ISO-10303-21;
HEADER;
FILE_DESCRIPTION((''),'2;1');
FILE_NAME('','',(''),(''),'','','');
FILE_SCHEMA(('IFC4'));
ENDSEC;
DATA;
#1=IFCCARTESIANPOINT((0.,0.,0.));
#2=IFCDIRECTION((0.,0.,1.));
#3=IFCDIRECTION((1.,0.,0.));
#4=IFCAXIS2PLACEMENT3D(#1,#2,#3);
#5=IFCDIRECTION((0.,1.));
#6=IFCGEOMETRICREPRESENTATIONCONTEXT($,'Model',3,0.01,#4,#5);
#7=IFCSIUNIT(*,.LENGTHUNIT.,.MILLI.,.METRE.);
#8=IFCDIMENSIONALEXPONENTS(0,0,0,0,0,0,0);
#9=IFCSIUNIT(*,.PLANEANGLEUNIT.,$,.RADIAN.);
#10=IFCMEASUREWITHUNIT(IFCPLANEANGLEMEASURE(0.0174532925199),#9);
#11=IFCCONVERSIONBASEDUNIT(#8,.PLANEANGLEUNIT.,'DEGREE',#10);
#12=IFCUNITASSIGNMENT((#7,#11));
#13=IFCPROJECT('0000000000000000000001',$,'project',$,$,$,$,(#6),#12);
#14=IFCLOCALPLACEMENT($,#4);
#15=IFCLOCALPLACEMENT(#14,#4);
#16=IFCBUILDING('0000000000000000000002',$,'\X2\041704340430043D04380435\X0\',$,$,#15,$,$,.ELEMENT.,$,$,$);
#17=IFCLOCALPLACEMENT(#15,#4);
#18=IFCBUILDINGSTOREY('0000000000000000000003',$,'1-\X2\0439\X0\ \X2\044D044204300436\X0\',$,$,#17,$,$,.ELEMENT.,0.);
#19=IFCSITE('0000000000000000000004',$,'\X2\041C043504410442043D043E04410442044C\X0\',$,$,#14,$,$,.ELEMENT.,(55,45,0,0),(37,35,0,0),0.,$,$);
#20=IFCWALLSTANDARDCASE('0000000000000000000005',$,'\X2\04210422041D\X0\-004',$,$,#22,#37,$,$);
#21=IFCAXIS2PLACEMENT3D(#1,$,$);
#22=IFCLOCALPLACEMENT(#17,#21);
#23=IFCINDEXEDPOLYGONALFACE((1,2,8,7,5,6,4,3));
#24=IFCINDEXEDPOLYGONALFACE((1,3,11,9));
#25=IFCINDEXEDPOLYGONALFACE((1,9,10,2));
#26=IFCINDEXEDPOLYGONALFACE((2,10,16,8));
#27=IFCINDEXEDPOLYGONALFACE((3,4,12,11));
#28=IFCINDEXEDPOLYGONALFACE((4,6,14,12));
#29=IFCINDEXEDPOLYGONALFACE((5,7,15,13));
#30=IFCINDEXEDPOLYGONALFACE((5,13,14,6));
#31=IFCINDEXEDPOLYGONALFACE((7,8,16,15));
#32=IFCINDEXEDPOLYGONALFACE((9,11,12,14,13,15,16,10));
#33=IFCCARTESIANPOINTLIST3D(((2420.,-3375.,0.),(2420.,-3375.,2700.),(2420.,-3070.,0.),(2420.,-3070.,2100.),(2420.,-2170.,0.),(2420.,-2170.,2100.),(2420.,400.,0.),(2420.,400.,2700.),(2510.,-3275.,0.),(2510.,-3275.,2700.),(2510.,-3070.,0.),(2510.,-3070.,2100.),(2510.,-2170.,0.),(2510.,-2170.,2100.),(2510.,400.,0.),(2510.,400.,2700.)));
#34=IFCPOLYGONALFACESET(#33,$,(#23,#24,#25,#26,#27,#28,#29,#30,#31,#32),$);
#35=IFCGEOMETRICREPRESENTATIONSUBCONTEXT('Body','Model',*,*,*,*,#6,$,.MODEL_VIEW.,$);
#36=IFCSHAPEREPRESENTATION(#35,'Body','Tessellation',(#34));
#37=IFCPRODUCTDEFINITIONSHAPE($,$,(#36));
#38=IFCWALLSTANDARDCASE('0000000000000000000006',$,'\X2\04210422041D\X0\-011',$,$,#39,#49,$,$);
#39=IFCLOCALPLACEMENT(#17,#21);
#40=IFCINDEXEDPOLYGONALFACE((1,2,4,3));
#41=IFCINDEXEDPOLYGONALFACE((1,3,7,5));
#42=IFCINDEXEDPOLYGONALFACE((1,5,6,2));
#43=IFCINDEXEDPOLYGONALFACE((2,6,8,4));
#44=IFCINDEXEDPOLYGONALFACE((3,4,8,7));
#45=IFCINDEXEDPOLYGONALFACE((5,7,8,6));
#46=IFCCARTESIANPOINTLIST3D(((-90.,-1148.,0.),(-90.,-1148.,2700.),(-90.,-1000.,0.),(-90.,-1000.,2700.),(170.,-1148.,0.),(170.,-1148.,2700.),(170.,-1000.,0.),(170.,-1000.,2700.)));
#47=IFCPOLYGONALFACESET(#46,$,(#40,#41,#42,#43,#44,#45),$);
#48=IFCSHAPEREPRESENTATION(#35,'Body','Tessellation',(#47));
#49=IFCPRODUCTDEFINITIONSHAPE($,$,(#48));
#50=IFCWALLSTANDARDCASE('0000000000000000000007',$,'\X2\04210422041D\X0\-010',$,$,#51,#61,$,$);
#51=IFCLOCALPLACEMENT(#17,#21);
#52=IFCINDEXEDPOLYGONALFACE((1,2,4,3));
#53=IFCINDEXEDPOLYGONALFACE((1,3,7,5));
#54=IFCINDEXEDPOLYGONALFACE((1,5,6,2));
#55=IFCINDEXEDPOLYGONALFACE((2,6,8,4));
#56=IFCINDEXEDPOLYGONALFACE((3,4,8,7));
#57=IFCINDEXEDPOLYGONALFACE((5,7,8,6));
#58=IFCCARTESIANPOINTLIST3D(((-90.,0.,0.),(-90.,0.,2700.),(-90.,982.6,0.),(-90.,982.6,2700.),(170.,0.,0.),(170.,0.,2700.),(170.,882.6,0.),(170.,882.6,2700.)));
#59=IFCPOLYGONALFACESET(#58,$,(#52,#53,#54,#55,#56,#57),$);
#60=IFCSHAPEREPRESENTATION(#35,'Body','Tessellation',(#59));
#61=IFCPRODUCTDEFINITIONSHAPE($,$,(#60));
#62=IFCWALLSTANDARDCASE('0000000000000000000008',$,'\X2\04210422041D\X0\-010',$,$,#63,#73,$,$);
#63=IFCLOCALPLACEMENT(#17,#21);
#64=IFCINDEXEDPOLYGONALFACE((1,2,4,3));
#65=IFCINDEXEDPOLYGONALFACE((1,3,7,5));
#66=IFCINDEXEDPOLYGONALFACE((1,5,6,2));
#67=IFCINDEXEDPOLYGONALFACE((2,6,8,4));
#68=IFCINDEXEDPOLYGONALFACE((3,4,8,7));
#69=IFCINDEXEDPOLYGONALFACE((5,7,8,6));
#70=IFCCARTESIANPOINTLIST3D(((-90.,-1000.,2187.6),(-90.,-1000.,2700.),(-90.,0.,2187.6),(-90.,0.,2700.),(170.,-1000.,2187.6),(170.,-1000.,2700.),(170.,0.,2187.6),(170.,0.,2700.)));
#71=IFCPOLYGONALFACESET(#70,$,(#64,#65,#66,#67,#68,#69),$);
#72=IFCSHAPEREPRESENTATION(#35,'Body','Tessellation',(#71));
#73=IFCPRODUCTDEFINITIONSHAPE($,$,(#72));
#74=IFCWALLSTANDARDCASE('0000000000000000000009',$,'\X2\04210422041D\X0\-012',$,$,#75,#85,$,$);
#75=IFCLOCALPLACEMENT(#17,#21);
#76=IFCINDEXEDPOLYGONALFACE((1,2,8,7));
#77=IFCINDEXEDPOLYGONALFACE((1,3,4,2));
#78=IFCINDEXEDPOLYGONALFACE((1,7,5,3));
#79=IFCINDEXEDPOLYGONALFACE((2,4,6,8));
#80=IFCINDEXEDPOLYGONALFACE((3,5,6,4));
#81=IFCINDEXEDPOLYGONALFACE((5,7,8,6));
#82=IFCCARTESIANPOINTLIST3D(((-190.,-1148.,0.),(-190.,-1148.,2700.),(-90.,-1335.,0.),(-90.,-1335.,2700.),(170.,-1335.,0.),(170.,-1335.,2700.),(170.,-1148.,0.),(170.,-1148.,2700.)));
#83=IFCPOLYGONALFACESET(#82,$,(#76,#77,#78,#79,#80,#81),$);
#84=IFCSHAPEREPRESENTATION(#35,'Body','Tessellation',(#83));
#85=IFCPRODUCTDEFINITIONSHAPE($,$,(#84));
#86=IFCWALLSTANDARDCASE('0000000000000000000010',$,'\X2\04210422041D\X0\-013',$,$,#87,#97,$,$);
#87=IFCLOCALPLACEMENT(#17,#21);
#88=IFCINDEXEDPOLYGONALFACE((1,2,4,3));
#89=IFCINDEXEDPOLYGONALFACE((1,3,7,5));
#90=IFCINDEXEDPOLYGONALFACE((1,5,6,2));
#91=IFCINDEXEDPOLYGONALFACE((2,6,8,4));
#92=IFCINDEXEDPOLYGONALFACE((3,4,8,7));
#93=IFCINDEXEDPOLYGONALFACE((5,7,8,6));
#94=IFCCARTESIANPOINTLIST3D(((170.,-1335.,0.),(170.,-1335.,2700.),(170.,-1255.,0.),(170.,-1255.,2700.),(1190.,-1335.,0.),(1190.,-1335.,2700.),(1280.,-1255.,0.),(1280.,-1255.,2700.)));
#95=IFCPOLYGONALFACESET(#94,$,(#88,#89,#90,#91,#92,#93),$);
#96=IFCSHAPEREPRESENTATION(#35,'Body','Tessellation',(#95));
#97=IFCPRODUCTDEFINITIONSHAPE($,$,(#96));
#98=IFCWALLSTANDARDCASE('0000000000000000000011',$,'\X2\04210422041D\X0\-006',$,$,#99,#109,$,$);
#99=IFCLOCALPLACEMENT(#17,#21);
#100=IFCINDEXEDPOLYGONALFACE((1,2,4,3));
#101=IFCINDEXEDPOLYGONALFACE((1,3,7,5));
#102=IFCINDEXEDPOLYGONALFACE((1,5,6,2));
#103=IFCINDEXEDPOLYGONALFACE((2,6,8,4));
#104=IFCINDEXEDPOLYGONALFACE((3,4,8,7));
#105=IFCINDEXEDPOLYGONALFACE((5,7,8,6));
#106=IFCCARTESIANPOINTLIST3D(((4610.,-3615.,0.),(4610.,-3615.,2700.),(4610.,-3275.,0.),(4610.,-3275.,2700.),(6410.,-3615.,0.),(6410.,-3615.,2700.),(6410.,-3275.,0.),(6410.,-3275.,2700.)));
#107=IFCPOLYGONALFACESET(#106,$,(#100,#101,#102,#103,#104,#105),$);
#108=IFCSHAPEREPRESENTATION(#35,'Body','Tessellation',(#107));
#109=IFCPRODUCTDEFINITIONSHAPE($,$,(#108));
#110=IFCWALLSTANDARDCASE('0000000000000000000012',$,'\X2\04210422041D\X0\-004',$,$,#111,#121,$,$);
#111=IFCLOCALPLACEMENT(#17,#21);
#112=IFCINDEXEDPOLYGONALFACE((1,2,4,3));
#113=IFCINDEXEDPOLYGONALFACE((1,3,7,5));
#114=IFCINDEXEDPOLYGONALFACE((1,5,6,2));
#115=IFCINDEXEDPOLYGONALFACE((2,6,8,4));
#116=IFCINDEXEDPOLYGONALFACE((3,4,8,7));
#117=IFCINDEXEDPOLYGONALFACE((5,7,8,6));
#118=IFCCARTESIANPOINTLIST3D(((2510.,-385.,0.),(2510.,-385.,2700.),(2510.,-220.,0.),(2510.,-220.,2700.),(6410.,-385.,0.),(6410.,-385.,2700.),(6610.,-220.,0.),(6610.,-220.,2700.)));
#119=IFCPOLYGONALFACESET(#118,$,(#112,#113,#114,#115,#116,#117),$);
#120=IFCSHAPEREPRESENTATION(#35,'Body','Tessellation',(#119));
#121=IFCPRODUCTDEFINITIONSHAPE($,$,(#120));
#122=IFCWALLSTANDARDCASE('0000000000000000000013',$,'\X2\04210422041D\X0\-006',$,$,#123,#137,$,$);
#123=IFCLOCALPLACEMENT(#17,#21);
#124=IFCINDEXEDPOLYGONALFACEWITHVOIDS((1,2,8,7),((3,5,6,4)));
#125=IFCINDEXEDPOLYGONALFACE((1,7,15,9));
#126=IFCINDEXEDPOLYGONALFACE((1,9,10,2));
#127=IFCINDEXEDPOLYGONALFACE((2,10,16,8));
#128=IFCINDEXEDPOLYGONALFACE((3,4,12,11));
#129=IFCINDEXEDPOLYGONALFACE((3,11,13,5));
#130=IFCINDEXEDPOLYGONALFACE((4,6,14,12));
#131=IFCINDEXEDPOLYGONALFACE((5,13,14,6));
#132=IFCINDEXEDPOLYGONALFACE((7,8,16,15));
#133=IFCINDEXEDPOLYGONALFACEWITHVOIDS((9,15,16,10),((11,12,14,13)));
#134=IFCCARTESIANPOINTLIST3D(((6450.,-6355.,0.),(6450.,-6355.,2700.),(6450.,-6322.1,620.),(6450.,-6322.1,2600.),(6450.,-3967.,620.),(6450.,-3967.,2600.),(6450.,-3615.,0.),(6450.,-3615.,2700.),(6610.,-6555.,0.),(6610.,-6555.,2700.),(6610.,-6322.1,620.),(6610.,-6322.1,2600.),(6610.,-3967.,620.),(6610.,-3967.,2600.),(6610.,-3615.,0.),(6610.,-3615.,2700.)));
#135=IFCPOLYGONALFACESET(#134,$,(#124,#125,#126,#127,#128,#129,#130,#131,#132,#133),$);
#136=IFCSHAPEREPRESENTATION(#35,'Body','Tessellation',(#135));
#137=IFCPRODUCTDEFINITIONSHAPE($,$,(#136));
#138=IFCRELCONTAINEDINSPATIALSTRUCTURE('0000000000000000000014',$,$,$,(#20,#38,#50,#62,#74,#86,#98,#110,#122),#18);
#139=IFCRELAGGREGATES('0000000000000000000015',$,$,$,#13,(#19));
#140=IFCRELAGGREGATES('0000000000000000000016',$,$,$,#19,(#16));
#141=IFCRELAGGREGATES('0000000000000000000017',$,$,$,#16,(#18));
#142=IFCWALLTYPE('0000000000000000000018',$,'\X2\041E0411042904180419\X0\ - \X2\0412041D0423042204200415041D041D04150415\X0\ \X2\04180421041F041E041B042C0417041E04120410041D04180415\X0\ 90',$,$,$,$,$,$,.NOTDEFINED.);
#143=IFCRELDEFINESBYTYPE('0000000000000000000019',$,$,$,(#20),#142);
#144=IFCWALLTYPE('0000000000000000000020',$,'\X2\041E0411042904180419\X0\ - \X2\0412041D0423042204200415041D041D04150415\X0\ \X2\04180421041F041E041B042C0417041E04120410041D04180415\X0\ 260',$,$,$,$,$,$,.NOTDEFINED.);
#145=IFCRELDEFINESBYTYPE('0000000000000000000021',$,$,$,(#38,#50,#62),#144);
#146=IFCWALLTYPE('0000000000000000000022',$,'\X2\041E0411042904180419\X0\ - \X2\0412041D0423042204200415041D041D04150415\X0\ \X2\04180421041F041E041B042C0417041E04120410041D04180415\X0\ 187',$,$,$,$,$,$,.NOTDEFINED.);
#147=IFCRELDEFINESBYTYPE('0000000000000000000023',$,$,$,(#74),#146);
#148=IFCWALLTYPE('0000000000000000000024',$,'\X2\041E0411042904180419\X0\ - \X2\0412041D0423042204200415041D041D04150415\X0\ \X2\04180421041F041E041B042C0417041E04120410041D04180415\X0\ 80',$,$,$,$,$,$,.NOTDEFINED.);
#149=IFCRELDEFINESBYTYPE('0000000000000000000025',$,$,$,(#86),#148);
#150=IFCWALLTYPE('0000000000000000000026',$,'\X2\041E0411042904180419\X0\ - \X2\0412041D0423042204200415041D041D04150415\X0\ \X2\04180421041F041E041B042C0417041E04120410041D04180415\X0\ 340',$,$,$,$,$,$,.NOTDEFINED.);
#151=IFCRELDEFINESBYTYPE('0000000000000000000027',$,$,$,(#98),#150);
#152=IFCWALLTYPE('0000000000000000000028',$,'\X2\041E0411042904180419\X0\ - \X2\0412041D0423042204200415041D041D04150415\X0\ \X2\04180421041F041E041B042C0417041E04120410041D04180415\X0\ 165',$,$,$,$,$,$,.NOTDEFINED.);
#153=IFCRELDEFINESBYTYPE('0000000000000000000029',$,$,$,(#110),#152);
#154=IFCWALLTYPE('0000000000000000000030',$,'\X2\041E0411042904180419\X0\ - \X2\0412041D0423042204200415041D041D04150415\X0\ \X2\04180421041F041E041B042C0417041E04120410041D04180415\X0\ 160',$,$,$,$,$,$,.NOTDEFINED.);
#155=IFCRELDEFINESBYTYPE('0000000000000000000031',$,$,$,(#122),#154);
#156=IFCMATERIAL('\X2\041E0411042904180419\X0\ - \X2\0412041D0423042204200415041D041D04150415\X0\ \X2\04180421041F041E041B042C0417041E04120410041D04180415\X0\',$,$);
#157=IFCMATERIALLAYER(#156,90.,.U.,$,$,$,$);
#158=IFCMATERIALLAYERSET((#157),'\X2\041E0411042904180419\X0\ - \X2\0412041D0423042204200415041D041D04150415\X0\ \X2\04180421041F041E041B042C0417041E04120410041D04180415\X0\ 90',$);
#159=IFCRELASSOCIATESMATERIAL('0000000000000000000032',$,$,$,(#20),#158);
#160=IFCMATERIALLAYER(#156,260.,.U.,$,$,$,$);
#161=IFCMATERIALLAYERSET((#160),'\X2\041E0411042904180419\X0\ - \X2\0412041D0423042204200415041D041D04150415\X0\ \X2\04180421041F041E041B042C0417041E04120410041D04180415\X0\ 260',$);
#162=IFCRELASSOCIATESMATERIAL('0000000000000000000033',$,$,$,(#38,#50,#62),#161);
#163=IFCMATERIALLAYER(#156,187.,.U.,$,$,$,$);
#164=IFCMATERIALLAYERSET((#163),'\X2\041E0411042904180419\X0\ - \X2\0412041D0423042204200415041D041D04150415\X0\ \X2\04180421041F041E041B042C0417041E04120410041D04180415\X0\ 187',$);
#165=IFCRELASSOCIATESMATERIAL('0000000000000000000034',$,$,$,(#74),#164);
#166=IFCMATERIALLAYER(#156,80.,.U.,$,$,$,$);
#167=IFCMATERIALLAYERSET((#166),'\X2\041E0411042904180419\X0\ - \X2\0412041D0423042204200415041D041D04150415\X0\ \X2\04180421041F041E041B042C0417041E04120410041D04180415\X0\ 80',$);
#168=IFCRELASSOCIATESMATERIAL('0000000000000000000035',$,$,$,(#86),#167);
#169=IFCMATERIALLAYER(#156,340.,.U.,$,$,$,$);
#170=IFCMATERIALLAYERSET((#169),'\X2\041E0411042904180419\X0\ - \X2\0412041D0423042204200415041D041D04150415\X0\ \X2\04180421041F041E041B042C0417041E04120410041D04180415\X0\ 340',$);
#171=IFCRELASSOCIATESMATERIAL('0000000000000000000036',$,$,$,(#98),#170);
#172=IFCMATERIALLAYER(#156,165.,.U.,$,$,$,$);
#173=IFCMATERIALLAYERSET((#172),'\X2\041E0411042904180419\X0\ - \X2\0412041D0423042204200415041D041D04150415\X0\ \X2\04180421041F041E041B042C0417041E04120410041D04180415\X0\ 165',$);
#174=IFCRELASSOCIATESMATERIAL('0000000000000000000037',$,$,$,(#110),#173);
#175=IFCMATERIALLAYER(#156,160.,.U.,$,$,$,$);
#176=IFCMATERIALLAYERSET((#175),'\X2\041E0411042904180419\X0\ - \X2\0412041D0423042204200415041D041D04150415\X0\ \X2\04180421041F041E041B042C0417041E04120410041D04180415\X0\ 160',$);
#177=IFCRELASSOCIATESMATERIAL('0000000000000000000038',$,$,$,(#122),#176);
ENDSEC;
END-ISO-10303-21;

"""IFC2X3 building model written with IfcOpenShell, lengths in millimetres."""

from ifc_helpers import new_model, entity, si_unit, converted_unit, direction, frame, origin_with_axes, origin_2d_with_axis, place, context, subcontext, project, spatial, polyline, rectangle, outline, extrude, material, layer, layer_set, layer_usage, type_object, element, save


model = new_model("IFC2X3")

# Units and contexts
model_context = context("Model", 3, precision=0.01, world=origin_with_axes(), true_north=direction((0.0, 1.0)))
body_context = subcontext(model_context, "Body", "Model", "MODEL_VIEW")
ifc_project = project(units=[si_unit("LENGTHUNIT", "METRE", prefix="MILLI"), converted_unit("PLANEANGLEUNIT", "DEGREE", entity("IfcPlaneAngleMeasure", 0.0174532925199), si_unit("PLANEANGLEUNIT", "RADIAN"), dimensions=[0, 0, 0, 0, 0, 0, 0])], contexts=[model_context])

# Site, building, storey
site_placement = place(None, origin_with_axes())
site = spatial("IfcSite", under=ifc_project, at=site_placement, Name="Местность", CompositionType="ELEMENT", RefLatitude=(55, 45, 0, 0), RefLongitude=(37, 35, 0, 0), RefElevation=0.0)
building_placement = place(site_placement, origin_with_axes())
building = spatial("IfcBuilding", under=site, at=building_placement, Name="Здание", CompositionType="ELEMENT")
storey_placement = place(building_placement, origin_with_axes())
storey = spatial("IfcBuildingStorey", under=building, at=storey_placement, Name="1-й этаж", CompositionType="ELEMENT", Elevation=0.0)

# Shared definitions
ifc_material = material(Name="ОБЩИЙ - ВНУТРЕННЕЕ ИСПОЛЬЗОВАНИЕ")

# Shared definitions
ifc_layer_1 = layer(ifc_material, 90.0, ventilated="UNKNOWN")
ifc_layer_set_1 = layer_set([ifc_layer_1], Name="ОБЩИЙ - ВНУТРЕННЕЕ ИСПОЛЬЗОВАНИЕ 90")
wall_type_1 = type_object("IfcWallType", Name="ОБЩИЙ - ВНУТРЕННЕЕ ИСПОЛЬЗОВАНИЕ 90", PredefinedType="NOTDEFINED")

# Wall, opening
ifc_layer_usage_1 = layer_usage(ifc_layer_set_1, "AXIS2", "POSITIVE", -90.0)
wall_1_placement = place(storey_placement, frame((2510.0, 400.0, 0.0), z_axis=(0.0, 0.0, 1.0), x_axis=(0.0, -1.0, 0.0)))
wall_1 = element("IfcWallStandardCase", 1, at=wall_1_placement, inside=storey, type_object=wall_type_1, material=ifc_layer_usage_1, Name="СТН-004", context=body_context, shape_type="SweptSolid", body=[
    extrude(outline(polyline([(0.0, -90.0), (3775.0, -90.0), (3675.0, 0.0), (0.0, 0.0), (0.0, -90.0)])), origin_with_axes(), (0.0, 0.0, 1.0), 2700.0),
])
opening_1_placement = place(wall_1_placement, frame((3020.0, 0.0, 0.0), z_axis=(0.0, 0.0, 1.0), x_axis=(1.0, 0.0, 0.0)))
element("IfcOpeningElement", 2, at=opening_1_placement, cuts=wall_1, context=body_context, shape_type="SweptSolid", body=[
    extrude(rectangle(XDim=900.0, YDim=2100.0, at=origin_2d_with_axis()), frame((0.0, 90.0, 1050.0), z_axis=(0.0, -1.0, 0.0), x_axis=(1.0, 0.0, 0.0)), (0.0, 0.0, 1.0), 270.0),
])

# Walls
ifc_layer_2 = layer(ifc_material, 260.0, ventilated="UNKNOWN")
ifc_layer_set_2 = layer_set([ifc_layer_2], Name="ОБЩИЙ - ВНУТРЕННЕЕ ИСПОЛЬЗОВАНИЕ 260")
ifc_layer_usage_2 = layer_usage(ifc_layer_set_2, "AXIS2", "POSITIVE", 0.0)
wall_type_2 = type_object("IfcWallType", Name="ОБЩИЙ - ВНУТРЕННЕЕ ИСПОЛЬЗОВАНИЕ 260", PredefinedType="NOTDEFINED")
wall_2_placement = place(storey_placement, frame((-90.0, -1000.0, 0.0), z_axis=(0.0, 0.0, 1.0), x_axis=(0.0, -1.0, 0.0)))
element("IfcWallStandardCase", 3, at=wall_2_placement, inside=storey, type_object=wall_type_2, material=ifc_layer_usage_2, Name="СТН-011", context=body_context, shape_type="SweptSolid", body=[
    extrude(outline(polyline([(0.0, 0.0), (148.0, 0.0), (148.0, 260.0), (0.0, 260.0), (0.0, 0.0)])), origin_with_axes(), (0.0, 0.0, 1.0), 2700.0),
])
ifc_layer_usage_3 = layer_usage(ifc_layer_set_2, "AXIS2", "POSITIVE", 0.0)
wall_3_placement = place(storey_placement, frame((-90.0, 982.6, 0.0), z_axis=(0.0, 0.0, 1.0), x_axis=(0.0, -1.0, 0.0)))
element("IfcWallStandardCase", 4, at=wall_3_placement, inside=storey, type_object=wall_type_2, material=ifc_layer_usage_3, Name="СТН-010", context=body_context, shape_type="SweptSolid", body=[
    extrude(outline(polyline([(0.0, 0.0), (982.6, 0.0), (982.6, 260.0), (100.0, 260.0), (0.0, 0.0)])), origin_with_axes(), (0.0, 0.0, 1.0), 2700.0),
])
ifc_layer_usage_4 = layer_usage(ifc_layer_set_2, "AXIS2", "POSITIVE", 0.0)
wall_4_placement = place(storey_placement, frame((-90.0, 0.0, 2187.6), z_axis=(0.0, 0.0, 1.0), x_axis=(0.0, -1.0, 0.0)))
element("IfcWallStandardCase", 5, at=wall_4_placement, inside=storey, type_object=wall_type_2, material=ifc_layer_usage_4, Name="СТН-010", context=body_context, shape_type="SweptSolid", body=[
    extrude(outline(polyline([(0.0, 0.0), (1000.0, 0.0), (1000.0, 260.0), (0.0, 260.0), (0.0, 0.0)])), origin_with_axes(), (0.0, 0.0, 1.0), 512.4),
])
ifc_layer_3 = layer(ifc_material, 187.0, ventilated="UNKNOWN")
ifc_layer_set_3 = layer_set([ifc_layer_3], Name="ОБЩИЙ - ВНУТРЕННЕЕ ИСПОЛЬЗОВАНИЕ 187")
ifc_layer_usage_5 = layer_usage(ifc_layer_set_3, "AXIS2", "POSITIVE", -187.0)
wall_type_3 = type_object("IfcWallType", Name="ОБЩИЙ - ВНУТРЕННЕЕ ИСПОЛЬЗОВАНИЕ 187", PredefinedType="NOTDEFINED")
wall_5_placement = place(storey_placement, frame((170.0, -1335.0, 0.0), z_axis=(0.0, 0.0, 1.0), x_axis=(-1.0, 0.0, 0.0)))
element("IfcWallStandardCase", 6, at=wall_5_placement, inside=storey, type_object=wall_type_3, material=ifc_layer_usage_5, Name="СТН-012", context=body_context, shape_type="SweptSolid", body=[
    extrude(outline(polyline([(0.0, -187.0), (360.0, -187.0), (260.0, 0.0), (0.0, 0.0), (0.0, -187.0)])), origin_with_axes(), (0.0, 0.0, 1.0), 2700.0),
])
ifc_layer_4 = layer(ifc_material, 80.0, ventilated="UNKNOWN")
ifc_layer_set_4 = layer_set([ifc_layer_4], Name="ОБЩИЙ - ВНУТРЕННЕЕ ИСПОЛЬЗОВАНИЕ 80")
ifc_layer_usage_6 = layer_usage(ifc_layer_set_4, "AXIS2", "POSITIVE", -80.0)
wall_type_4 = type_object("IfcWallType", Name="ОБЩИЙ - ВНУТРЕННЕЕ ИСПОЛЬЗОВАНИЕ 80", PredefinedType="NOTDEFINED")
wall_6_placement = place(storey_placement, frame((1190.0, -1335.0, 0.0), z_axis=(0.0, 0.0, 1.0), x_axis=(-1.0, 0.0, 0.0)))
element("IfcWallStandardCase", 7, at=wall_6_placement, inside=storey, type_object=wall_type_4, material=ifc_layer_usage_6, Name="СТН-013", context=body_context, shape_type="SweptSolid", body=[
    extrude(outline(polyline([(-90.0, -80.0), (1020.0, -80.0), (1020.0, 0.0), (0.0, 0.0), (-90.0, -80.0)])), origin_with_axes(), (0.0, 0.0, 1.0), 2700.0),
])
ifc_layer_5 = layer(ifc_material, 340.0, ventilated="UNKNOWN")
ifc_layer_set_5 = layer_set([ifc_layer_5], Name="ОБЩИЙ - ВНУТРЕННЕЕ ИСПОЛЬЗОВАНИЕ 340")
ifc_layer_usage_7 = layer_usage(ifc_layer_set_5, "AXIS2", "POSITIVE", -340.0)
wall_type_5 = type_object("IfcWallType", Name="ОБЩИЙ - ВНУТРЕННЕЕ ИСПОЛЬЗОВАНИЕ 340", PredefinedType="NOTDEFINED")
wall_7_placement = place(storey_placement, frame((4610.0, -3275.0, 0.0), z_axis=(0.0, 0.0, 1.0), x_axis=(1.0, 0.0, 0.0)))
element("IfcWallStandardCase", 8, at=wall_7_placement, inside=storey, type_object=wall_type_5, material=ifc_layer_usage_7, Name="СТН-006", context=body_context, shape_type="SweptSolid", body=[
    extrude(outline(polyline([(0.0, -340.0), (1800.0, -340.0), (1800.0, 0.0), (0.0, 0.0), (0.0, -340.0)])), origin_with_axes(), (0.0, 0.0, 1.0), 2700.0),
])
ifc_layer_6 = layer(ifc_material, 165.0, ventilated="UNKNOWN")
ifc_layer_set_6 = layer_set([ifc_layer_6], Name="ОБЩИЙ - ВНУТРЕННЕЕ ИСПОЛЬЗОВАНИЕ 165")
ifc_layer_usage_8 = layer_usage(ifc_layer_set_6, "AXIS2", "POSITIVE", -165.0)
wall_type_6 = type_object("IfcWallType", Name="ОБЩИЙ - ВНУТРЕННЕЕ ИСПОЛЬЗОВАНИЕ 165", PredefinedType="NOTDEFINED")
wall_8_placement = place(storey_placement, frame((2510.0, -220.0, 0.0), z_axis=(0.0, 0.0, 1.0), x_axis=(1.0, 0.0, 0.0)))
element("IfcWallStandardCase", 9, at=wall_8_placement, inside=storey, type_object=wall_type_6, material=ifc_layer_usage_8, Name="СТН-004", context=body_context, shape_type="SweptSolid", body=[
    extrude(outline(polyline([(0.0, -165.0), (3900.0, -165.0), (4100.0, 0.0), (0.0, 0.0), (0.0, -165.0)])), origin_with_axes(), (0.0, 0.0, 1.0), 2700.0),
])

# Wall, opening
ifc_layer_7 = layer(ifc_material, 160.0, ventilated="UNKNOWN")
ifc_layer_set_7 = layer_set([ifc_layer_7], Name="ОБЩИЙ - ВНУТРЕННЕЕ ИСПОЛЬЗОВАНИЕ 160")
ifc_layer_usage_9 = layer_usage(ifc_layer_set_7, "AXIS2", "POSITIVE", -160.0)
wall_type_7 = type_object("IfcWallType", Name="ОБЩИЙ - ВНУТРЕННЕЕ ИСПОЛЬЗОВАНИЕ 160", PredefinedType="NOTDEFINED")
wall_9_placement = place(storey_placement, frame((6610.0, -3615.0, 0.0), z_axis=(0.0, 0.0, 1.0), x_axis=(0.0, -1.0, 0.0)))
wall_9 = element("IfcWallStandardCase", 10, at=wall_9_placement, inside=storey, type_object=wall_type_7, material=ifc_layer_usage_9, Name="СТН-006", context=body_context, shape_type="SweptSolid", body=[
    extrude(outline(polyline([(0.0, -160.0), (2740.0, -160.0), (2940.0, 0.0), (0.0, 0.0), (0.0, -160.0)])), origin_with_axes(), (0.0, 0.0, 1.0), 2700.0),
])
opening_2_placement = place(wall_9_placement, frame((1529.5, 0.0, 620.0), z_axis=(0.0, 0.0, 1.0), x_axis=(1.0, 0.0, 0.0)))
element("IfcOpeningElement", 11, at=opening_2_placement, cuts=wall_9, context=body_context, shape_type="SweptSolid", body=[
    extrude(rectangle(XDim=2355.1, YDim=1980.0, at=origin_2d_with_axis()), frame((0.0, -160.0, 990.0), z_axis=(0.0, 1.0, 0.0), x_axis=(-1.0, 0.0, 0.0)), (0.0, 0.0, 1.0), 480.0),
])

save(model, "model.ifc")
